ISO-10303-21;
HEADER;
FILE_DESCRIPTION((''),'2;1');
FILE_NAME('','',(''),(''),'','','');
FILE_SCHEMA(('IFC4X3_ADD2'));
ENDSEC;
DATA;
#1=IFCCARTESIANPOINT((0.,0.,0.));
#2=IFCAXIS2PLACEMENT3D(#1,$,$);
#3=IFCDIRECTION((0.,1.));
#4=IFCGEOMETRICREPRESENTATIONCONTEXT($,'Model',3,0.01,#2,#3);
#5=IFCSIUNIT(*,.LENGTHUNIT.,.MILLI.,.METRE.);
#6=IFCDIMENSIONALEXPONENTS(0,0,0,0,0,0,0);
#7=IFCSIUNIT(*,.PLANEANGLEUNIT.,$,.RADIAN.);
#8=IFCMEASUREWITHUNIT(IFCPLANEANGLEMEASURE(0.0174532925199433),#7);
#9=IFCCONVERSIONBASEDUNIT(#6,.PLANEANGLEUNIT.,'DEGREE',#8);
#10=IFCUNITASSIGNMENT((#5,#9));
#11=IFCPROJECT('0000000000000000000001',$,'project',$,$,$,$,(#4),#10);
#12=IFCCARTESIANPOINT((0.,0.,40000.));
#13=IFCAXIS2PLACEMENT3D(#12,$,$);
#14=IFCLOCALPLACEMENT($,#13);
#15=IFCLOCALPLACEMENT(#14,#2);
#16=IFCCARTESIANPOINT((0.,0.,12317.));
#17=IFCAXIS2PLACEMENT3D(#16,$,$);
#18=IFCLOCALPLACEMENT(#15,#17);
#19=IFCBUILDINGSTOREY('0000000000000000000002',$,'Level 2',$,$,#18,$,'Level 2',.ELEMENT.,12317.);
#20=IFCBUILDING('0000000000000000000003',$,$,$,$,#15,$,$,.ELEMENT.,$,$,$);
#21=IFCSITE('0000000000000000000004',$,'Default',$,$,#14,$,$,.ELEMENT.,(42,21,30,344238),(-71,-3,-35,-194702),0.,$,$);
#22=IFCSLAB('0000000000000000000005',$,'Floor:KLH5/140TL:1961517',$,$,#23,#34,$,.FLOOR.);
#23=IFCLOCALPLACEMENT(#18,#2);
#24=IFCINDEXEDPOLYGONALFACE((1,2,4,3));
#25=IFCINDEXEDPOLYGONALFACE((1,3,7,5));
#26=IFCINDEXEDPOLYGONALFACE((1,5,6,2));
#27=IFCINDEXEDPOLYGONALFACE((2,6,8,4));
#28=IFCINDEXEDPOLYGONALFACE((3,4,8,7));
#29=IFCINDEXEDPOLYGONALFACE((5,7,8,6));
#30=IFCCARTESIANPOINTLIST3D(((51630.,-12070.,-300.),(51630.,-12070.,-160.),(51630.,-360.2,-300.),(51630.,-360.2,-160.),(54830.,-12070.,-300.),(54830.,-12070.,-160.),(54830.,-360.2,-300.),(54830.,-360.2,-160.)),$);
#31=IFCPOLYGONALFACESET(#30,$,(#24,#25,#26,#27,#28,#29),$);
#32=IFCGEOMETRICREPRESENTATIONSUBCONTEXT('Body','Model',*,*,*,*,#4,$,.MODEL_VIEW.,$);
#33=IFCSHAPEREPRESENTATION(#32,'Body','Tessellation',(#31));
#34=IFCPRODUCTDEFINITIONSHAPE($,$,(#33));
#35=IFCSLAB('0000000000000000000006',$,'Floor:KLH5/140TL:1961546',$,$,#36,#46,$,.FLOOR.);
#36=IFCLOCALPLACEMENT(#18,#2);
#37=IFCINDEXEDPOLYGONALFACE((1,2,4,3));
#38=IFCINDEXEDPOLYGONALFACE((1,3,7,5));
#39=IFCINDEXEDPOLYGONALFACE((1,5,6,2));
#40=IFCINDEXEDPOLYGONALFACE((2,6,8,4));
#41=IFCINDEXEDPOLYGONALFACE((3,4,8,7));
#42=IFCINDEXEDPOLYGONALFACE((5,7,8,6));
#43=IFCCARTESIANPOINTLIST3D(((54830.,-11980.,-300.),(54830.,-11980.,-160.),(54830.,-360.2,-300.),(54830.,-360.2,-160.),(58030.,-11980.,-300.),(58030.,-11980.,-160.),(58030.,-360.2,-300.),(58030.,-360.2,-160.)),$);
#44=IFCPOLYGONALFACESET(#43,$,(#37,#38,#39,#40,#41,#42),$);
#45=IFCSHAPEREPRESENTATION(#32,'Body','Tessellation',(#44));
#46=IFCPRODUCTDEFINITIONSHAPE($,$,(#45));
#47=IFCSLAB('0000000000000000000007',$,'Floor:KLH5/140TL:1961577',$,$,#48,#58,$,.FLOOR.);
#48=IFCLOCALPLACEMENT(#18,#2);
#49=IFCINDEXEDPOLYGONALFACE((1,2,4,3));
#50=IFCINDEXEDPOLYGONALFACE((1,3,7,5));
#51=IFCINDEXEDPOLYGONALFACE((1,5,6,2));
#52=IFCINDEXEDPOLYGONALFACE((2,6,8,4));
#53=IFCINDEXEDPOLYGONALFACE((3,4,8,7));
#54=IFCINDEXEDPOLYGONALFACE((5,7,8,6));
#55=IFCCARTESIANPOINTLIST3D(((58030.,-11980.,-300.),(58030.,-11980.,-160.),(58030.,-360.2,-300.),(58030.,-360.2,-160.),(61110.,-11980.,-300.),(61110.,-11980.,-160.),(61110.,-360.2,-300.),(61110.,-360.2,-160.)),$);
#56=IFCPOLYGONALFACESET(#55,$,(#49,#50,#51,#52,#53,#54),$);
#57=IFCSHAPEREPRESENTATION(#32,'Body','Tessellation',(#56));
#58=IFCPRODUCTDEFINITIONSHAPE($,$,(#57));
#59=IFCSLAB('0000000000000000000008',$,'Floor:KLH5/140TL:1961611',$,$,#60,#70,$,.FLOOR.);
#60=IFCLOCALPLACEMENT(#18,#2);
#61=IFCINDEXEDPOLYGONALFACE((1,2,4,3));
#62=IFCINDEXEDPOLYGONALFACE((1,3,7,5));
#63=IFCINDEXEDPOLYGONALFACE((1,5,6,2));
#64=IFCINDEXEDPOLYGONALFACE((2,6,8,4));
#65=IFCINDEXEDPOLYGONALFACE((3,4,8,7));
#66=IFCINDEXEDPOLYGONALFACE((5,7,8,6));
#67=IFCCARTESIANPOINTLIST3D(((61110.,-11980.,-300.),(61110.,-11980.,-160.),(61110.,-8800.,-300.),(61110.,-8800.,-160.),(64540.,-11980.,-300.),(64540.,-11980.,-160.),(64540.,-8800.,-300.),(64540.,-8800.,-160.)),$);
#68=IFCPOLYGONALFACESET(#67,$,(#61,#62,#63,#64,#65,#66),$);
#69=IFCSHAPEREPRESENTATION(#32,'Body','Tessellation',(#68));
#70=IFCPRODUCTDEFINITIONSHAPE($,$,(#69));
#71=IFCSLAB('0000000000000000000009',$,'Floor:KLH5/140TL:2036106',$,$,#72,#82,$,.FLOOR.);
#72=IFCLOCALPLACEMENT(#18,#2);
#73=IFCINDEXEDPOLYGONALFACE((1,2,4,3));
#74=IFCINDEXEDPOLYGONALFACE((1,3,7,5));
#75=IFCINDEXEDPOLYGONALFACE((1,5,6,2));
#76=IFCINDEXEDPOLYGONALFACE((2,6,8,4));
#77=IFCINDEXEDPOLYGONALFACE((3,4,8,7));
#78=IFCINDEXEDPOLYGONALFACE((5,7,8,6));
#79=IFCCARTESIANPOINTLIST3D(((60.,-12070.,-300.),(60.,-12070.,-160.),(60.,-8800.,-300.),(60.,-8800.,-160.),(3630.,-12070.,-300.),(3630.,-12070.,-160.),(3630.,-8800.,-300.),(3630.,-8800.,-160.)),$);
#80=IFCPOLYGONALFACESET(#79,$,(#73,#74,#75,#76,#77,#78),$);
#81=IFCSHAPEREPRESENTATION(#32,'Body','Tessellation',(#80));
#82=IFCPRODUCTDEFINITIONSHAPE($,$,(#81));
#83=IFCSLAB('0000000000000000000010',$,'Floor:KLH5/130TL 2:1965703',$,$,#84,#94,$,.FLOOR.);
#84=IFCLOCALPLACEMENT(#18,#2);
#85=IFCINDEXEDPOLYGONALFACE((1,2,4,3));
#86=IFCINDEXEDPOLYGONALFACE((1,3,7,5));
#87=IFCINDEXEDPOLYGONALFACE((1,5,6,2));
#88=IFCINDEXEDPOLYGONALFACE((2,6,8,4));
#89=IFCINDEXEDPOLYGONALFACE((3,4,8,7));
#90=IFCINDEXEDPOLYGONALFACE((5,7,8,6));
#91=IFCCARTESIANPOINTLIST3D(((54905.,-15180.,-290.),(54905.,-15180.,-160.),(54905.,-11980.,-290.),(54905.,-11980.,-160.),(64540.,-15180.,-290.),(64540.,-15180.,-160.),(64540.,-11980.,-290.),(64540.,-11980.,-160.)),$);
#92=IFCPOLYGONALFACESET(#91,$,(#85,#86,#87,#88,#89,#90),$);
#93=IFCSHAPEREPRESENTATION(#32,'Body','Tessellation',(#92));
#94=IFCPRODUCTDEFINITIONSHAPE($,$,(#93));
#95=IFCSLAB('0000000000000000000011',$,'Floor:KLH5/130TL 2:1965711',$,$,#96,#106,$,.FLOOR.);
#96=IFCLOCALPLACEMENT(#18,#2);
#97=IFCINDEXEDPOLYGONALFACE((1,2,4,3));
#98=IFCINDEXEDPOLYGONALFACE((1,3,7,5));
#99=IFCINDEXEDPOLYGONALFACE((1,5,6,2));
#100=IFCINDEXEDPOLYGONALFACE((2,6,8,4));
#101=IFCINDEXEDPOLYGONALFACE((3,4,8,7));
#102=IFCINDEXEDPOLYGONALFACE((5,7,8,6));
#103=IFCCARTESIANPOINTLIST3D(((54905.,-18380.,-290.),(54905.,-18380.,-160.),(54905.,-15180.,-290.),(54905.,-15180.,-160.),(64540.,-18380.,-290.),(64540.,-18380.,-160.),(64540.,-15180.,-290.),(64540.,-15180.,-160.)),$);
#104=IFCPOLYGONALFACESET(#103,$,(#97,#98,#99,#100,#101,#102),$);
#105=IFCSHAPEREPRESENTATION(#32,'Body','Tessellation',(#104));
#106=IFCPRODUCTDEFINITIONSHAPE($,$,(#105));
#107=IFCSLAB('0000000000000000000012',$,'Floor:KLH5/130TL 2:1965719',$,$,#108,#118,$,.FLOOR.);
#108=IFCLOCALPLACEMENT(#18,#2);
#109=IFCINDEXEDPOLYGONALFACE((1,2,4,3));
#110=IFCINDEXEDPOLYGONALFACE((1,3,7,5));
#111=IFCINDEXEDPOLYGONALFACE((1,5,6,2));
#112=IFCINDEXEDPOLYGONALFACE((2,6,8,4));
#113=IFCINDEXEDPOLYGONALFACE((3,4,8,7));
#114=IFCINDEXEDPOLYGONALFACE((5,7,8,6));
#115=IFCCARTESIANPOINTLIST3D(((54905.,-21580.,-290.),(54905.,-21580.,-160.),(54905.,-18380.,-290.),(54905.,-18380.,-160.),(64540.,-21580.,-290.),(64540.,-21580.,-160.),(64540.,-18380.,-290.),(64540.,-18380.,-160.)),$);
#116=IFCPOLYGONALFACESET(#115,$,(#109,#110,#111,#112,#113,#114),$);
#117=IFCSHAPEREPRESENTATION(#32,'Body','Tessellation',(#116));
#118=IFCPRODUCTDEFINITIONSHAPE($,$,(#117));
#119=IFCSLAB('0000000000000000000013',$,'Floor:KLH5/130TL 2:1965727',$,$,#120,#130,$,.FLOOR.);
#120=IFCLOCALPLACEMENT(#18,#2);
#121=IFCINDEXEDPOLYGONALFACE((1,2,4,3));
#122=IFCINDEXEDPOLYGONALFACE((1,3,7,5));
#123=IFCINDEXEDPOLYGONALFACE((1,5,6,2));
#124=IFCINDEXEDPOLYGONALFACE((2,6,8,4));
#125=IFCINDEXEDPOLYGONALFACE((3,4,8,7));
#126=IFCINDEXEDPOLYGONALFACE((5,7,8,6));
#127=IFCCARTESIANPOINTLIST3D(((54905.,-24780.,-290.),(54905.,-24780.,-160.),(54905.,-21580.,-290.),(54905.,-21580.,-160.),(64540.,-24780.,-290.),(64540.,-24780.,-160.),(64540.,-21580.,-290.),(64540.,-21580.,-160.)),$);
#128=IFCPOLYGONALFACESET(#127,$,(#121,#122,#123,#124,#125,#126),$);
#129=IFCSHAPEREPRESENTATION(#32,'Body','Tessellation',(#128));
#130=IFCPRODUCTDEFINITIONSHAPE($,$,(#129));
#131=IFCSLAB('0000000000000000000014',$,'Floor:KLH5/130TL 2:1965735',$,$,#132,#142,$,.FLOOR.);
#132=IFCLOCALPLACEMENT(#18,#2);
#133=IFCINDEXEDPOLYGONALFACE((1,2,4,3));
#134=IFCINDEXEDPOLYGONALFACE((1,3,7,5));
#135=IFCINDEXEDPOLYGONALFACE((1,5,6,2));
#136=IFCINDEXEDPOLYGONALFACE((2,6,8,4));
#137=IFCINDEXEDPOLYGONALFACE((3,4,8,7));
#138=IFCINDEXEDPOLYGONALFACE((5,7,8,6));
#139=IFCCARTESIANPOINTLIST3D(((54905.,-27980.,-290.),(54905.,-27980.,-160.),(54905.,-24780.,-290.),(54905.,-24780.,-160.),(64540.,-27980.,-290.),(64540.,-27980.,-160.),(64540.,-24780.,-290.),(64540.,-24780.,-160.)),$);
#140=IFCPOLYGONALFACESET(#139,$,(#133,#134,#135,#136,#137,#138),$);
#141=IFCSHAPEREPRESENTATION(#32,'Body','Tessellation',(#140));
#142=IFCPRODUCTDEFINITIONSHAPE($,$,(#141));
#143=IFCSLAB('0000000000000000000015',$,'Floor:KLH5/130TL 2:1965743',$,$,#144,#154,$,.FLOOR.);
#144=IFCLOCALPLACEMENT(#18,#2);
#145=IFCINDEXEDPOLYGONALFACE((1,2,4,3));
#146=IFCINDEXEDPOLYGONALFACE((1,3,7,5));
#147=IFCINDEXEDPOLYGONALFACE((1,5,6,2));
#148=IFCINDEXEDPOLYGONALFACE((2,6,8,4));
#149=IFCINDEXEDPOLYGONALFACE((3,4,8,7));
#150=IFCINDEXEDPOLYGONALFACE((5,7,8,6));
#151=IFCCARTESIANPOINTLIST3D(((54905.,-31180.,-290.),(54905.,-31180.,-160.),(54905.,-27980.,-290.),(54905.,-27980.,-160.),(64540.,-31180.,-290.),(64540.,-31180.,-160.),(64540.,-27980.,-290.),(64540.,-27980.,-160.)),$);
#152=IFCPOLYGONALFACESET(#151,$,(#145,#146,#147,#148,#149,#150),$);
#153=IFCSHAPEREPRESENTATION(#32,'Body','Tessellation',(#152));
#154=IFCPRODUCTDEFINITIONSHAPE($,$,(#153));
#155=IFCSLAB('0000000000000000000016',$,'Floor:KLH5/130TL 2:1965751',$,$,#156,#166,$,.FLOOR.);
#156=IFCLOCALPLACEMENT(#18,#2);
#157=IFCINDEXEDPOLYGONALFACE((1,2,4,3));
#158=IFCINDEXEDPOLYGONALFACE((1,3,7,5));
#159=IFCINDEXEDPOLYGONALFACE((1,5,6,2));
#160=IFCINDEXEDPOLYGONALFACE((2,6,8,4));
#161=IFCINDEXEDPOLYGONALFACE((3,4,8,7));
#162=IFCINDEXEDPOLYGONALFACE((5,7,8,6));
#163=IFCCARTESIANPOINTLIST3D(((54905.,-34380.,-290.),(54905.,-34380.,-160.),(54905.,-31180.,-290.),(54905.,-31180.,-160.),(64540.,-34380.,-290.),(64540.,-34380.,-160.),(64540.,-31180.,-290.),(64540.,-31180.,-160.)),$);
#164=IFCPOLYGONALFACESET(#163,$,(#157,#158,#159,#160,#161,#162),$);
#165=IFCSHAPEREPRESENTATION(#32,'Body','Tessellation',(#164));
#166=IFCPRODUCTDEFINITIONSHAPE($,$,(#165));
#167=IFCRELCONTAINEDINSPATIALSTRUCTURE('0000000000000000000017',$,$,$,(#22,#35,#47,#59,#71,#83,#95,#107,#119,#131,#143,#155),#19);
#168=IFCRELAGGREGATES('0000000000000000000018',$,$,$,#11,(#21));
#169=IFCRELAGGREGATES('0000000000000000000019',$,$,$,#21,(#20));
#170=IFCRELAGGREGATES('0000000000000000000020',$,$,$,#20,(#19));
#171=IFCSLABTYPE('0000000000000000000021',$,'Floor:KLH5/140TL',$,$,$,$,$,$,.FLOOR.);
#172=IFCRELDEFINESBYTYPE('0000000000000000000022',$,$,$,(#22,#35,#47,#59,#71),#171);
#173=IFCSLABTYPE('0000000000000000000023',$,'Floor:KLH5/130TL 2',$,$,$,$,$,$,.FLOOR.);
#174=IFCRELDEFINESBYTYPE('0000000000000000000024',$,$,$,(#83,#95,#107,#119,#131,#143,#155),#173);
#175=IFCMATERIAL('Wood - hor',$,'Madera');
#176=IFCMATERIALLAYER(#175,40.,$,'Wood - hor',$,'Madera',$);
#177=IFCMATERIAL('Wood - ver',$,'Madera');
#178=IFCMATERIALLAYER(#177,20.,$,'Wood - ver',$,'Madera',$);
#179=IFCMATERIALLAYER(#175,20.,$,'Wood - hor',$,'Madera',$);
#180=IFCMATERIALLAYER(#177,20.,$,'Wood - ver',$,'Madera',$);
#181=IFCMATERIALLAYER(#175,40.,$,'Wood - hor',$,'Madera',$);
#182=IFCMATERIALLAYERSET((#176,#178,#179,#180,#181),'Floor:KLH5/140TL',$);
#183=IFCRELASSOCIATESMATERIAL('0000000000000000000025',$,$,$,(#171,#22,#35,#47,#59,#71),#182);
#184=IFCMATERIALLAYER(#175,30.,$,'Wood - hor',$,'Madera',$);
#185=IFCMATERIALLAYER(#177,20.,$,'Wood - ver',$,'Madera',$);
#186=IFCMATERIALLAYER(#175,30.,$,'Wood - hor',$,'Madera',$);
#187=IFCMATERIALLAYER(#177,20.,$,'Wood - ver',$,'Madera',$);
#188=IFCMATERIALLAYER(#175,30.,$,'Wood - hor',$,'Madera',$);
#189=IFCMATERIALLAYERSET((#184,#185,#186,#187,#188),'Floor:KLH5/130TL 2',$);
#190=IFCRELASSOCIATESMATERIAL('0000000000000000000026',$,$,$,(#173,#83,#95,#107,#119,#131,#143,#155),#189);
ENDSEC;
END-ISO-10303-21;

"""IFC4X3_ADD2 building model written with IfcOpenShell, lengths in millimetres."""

from ifc_helpers import new_model, entity, si_unit, converted_unit, direction, frame, frame_2d, origin, origin_2d_with_axis, place, context, subcontext, project, spatial, rectangle, extrude, material, layer, layer_set, layer_usage, type_object, element, save


model = new_model("IFC4X3_ADD2")

# Units and contexts
model_context = context("Model", 3, precision=0.01, world=origin(), true_north=direction((0.0, 1.0)))
body_context = subcontext(model_context, "Body", "Model", "MODEL_VIEW")
ifc_project = project(units=[si_unit("LENGTHUNIT", "METRE", prefix="MILLI"), converted_unit("PLANEANGLEUNIT", "DEGREE", entity("IfcPlaneAngleMeasure", 0.0174532925199433), si_unit("PLANEANGLEUNIT", "RADIAN"), dimensions=[0, 0, 0, 0, 0, 0, 0])], contexts=[model_context])

# Site, building, storey
site_placement = place(None, frame((0.0, 0.0, 40000.0)))
site = spatial("IfcSite", under=ifc_project, at=site_placement, Name="Default", CompositionType="ELEMENT", RefLatitude=(42, 21, 30, 344238), RefLongitude=(-71, -3, -35, -194702), RefElevation=0.0)
building_placement = place(site_placement, origin())
building = spatial("IfcBuilding", under=site, at=building_placement, CompositionType="ELEMENT")
storey_placement = place(building_placement, frame((0.0, 0.0, 12317.0)))
storey = spatial("IfcBuildingStorey", under=building, at=storey_placement, Name="Level 2", LongName="Level 2", CompositionType="ELEMENT", Elevation=12317.0)

# Slabs
ifc_material_1 = material(Name="Wood - hor", Category="Madera")
ifc_layer_1 = layer(ifc_material_1, 40.0, Name="Wood - hor", Category="Madera")
ifc_material_2 = material(Name="Wood - ver", Category="Madera")
ifc_layer_2 = layer(ifc_material_2, 20.0, Name="Wood - ver", Category="Madera")
ifc_layer_3 = layer(ifc_material_1, 20.0, Name="Wood - hor", Category="Madera")
ifc_layer_4 = layer(ifc_material_2, 20.0, Name="Wood - ver", Category="Madera")
ifc_layer_5 = layer(ifc_material_1, 40.0, Name="Wood - hor", Category="Madera")
ifc_layer_set_1 = layer_set([ifc_layer_1, ifc_layer_2, ifc_layer_3, ifc_layer_4, ifc_layer_5], Name="Floor:KLH5/140TL")
slab_type_1 = type_object("IfcSlabType", Name="Floor:KLH5/140TL", PredefinedType="FLOOR", material=ifc_layer_set_1)
ifc_layer_usage_1 = layer_usage(ifc_layer_set_1, "AXIS3", "POSITIVE", 0.0)
slab_1_placement = place(storey_placement, origin())
element("IfcSlab", 1, at=slab_1_placement, inside=storey, type_object=slab_type_1, material=ifc_layer_usage_1, Name="Floor:KLH5/140TL:1961517", PredefinedType="FLOOR", context=body_context, shape_type="SweptSolid", body=[
    extrude(rectangle(XDim=11709.8, YDim=3200.0, at=frame_2d((0.0, 0.0), x_axis=(1.0, 0.0))), frame((53230.0, -6215.1, -160.0), z_axis=(0.0, 0.0, -1.0), x_axis=(0.0, 1.0, 0.0)), (0.0, 0.0, 1.0), 140.0),
])
ifc_layer_usage_2 = layer_usage(ifc_layer_set_1, "AXIS3", "POSITIVE", 0.0)
slab_2_placement = place(storey_placement, origin())
element("IfcSlab", 2, at=slab_2_placement, inside=storey, type_object=slab_type_1, material=ifc_layer_usage_2, Name="Floor:KLH5/140TL:1961546", PredefinedType="FLOOR", context=body_context, shape_type="SweptSolid", body=[
    extrude(rectangle(XDim=11619.8, YDim=3200.0, at=origin_2d_with_axis()), frame((56430.0, -6170.1, -160.0), z_axis=(0.0, 0.0, -1.0), x_axis=(0.0, 1.0, 0.0)), (0.0, 0.0, 1.0), 140.0),
])
ifc_layer_usage_3 = layer_usage(ifc_layer_set_1, "AXIS3", "POSITIVE", 0.0)
slab_3_placement = place(storey_placement, origin())
element("IfcSlab", 3, at=slab_3_placement, inside=storey, type_object=slab_type_1, material=ifc_layer_usage_3, Name="Floor:KLH5/140TL:1961577", PredefinedType="FLOOR", context=body_context, shape_type="SweptSolid", body=[
    extrude(rectangle(XDim=11619.8, YDim=3080.0, at=origin_2d_with_axis()), frame((59570.0, -6170.1, -160.0), z_axis=(0.0, 0.0, -1.0), x_axis=(0.0, 1.0, 0.0)), (0.0, 0.0, 1.0), 140.0),
])
ifc_layer_usage_4 = layer_usage(ifc_layer_set_1, "AXIS3", "POSITIVE", 0.0)
slab_4_placement = place(storey_placement, origin())
element("IfcSlab", 4, at=slab_4_placement, inside=storey, type_object=slab_type_1, material=ifc_layer_usage_4, Name="Floor:KLH5/140TL:1961611", PredefinedType="FLOOR", context=body_context, shape_type="SweptSolid", body=[
    extrude(rectangle(XDim=3180.0, YDim=3430.0, at=frame_2d((0.0, 0.0), x_axis=(1.0, 0.0))), frame((62825.0, -10390.0, -160.0), z_axis=(0.0, 0.0, -1.0), x_axis=(0.0, 1.0, 0.0)), (0.0, 0.0, 1.0), 140.0),
])
ifc_layer_usage_5 = layer_usage(ifc_layer_set_1, "AXIS3", "POSITIVE", 0.0)
slab_5_placement = place(storey_placement, origin())
element("IfcSlab", 5, at=slab_5_placement, inside=storey, type_object=slab_type_1, material=ifc_layer_usage_5, Name="Floor:KLH5/140TL:2036106", PredefinedType="FLOOR", context=body_context, shape_type="SweptSolid", body=[
    extrude(rectangle(XDim=3270.0, YDim=3570.0, at=frame_2d((0.0, 0.0), x_axis=(1.0, 0.0))), frame((1845.0, -10435.0, -160.0), z_axis=(0.0, 0.0, -1.0), x_axis=(0.0, 1.0, 0.0)), (0.0, 0.0, 1.0), 140.0),
])
ifc_layer_6 = layer(ifc_material_1, 30.0, Name="Wood - hor", Category="Madera")
ifc_layer_7 = layer(ifc_material_2, 20.0, Name="Wood - ver", Category="Madera")
ifc_layer_8 = layer(ifc_material_1, 30.0, Name="Wood - hor", Category="Madera")
ifc_layer_9 = layer(ifc_material_2, 20.0, Name="Wood - ver", Category="Madera")
ifc_layer_10 = layer(ifc_material_1, 30.0, Name="Wood - hor", Category="Madera")
ifc_layer_set_2 = layer_set([ifc_layer_6, ifc_layer_7, ifc_layer_8, ifc_layer_9, ifc_layer_10], Name="Floor:KLH5/130TL 2")
ifc_layer_usage_6 = layer_usage(ifc_layer_set_2, "AXIS3", "POSITIVE", 0.0)
slab_type_2 = type_object("IfcSlabType", Name="Floor:KLH5/130TL 2", PredefinedType="FLOOR", material=ifc_layer_set_2)
slab_6_placement = place(storey_placement, origin())
element("IfcSlab", 6, at=slab_6_placement, inside=storey, type_object=slab_type_2, material=ifc_layer_usage_6, Name="Floor:KLH5/130TL 2:1965703", PredefinedType="FLOOR", context=body_context, shape_type="SweptSolid", body=[
    extrude(rectangle(XDim=3200.0, YDim=9635.0, at=origin_2d_with_axis()), frame((59722.5, -13580.0, -160.0), z_axis=(0.0, 0.0, -1.0), x_axis=(0.0, 1.0, 0.0)), (0.0, 0.0, 1.0), 130.0),
])
ifc_layer_usage_7 = layer_usage(ifc_layer_set_2, "AXIS3", "POSITIVE", 0.0)
slab_7_placement = place(storey_placement, origin())
element("IfcSlab", 7, at=slab_7_placement, inside=storey, type_object=slab_type_2, material=ifc_layer_usage_7, Name="Floor:KLH5/130TL 2:1965711", PredefinedType="FLOOR", context=body_context, shape_type="SweptSolid", body=[
    extrude(rectangle(XDim=3200.0, YDim=9635.0, at=frame_2d((0.0, 0.0), x_axis=(1.0, 0.0))), frame((59722.5, -16780.0, -160.0), z_axis=(0.0, 0.0, -1.0), x_axis=(0.0, 1.0, 0.0)), (0.0, 0.0, 1.0), 130.0),
])
ifc_layer_usage_8 = layer_usage(ifc_layer_set_2, "AXIS3", "POSITIVE", 0.0)
slab_8_placement = place(storey_placement, origin())
element("IfcSlab", 8, at=slab_8_placement, inside=storey, type_object=slab_type_2, material=ifc_layer_usage_8, Name="Floor:KLH5/130TL 2:1965719", PredefinedType="FLOOR", context=body_context, shape_type="SweptSolid", body=[
    extrude(rectangle(XDim=3200.0, YDim=9635.0, at=frame_2d((0.0, 0.0), x_axis=(1.0, 0.0))), frame((59722.5, -19980.0, -160.0), z_axis=(0.0, 0.0, -1.0), x_axis=(0.0, 1.0, 0.0)), (0.0, 0.0, 1.0), 130.0),
])
ifc_layer_usage_9 = layer_usage(ifc_layer_set_2, "AXIS3", "POSITIVE", 0.0)
slab_9_placement = place(storey_placement, origin())
element("IfcSlab", 9, at=slab_9_placement, inside=storey, type_object=slab_type_2, material=ifc_layer_usage_9, Name="Floor:KLH5/130TL 2:1965727", PredefinedType="FLOOR", context=body_context, shape_type="SweptSolid", body=[
    extrude(rectangle(XDim=3200.0, YDim=9635.0, at=origin_2d_with_axis()), frame((59722.5, -23180.0, -160.0), z_axis=(0.0, 0.0, -1.0), x_axis=(0.0, 1.0, 0.0)), (0.0, 0.0, 1.0), 130.0),
])
ifc_layer_usage_10 = layer_usage(ifc_layer_set_2, "AXIS3", "POSITIVE", 0.0)
slab_10_placement = place(storey_placement, origin())
element("IfcSlab", 10, at=slab_10_placement, inside=storey, type_object=slab_type_2, material=ifc_layer_usage_10, Name="Floor:KLH5/130TL 2:1965735", PredefinedType="FLOOR", context=body_context, shape_type="SweptSolid", body=[
    extrude(rectangle(XDim=3200.0, YDim=9635.0, at=origin_2d_with_axis()), frame((59722.5, -26380.0, -160.0), z_axis=(0.0, 0.0, -1.0), x_axis=(0.0, 1.0, 0.0)), (0.0, 0.0, 1.0), 130.0),
])
ifc_layer_usage_11 = layer_usage(ifc_layer_set_2, "AXIS3", "POSITIVE", 0.0)
slab_11_placement = place(storey_placement, origin())
element("IfcSlab", 11, at=slab_11_placement, inside=storey, type_object=slab_type_2, material=ifc_layer_usage_11, Name="Floor:KLH5/130TL 2:1965743", PredefinedType="FLOOR", context=body_context, shape_type="SweptSolid", body=[
    extrude(rectangle(XDim=3200.0, YDim=9635.0, at=frame_2d((0.0, 0.0), x_axis=(1.0, 0.0))), frame((59722.5, -29580.0, -160.0), z_axis=(0.0, 0.0, -1.0), x_axis=(0.0, 1.0, 0.0)), (0.0, 0.0, 1.0), 130.0),
])
ifc_layer_usage_12 = layer_usage(ifc_layer_set_2, "AXIS3", "POSITIVE", 0.0)
slab_12_placement = place(storey_placement, origin())
element("IfcSlab", 12, at=slab_12_placement, inside=storey, type_object=slab_type_2, material=ifc_layer_usage_12, Name="Floor:KLH5/130TL 2:1965751", PredefinedType="FLOOR", context=body_context, shape_type="SweptSolid", body=[
    extrude(rectangle(XDim=3200.0, YDim=9635.0, at=origin_2d_with_axis()), frame((59722.5, -32780.0, -160.0), z_axis=(0.0, 0.0, -1.0), x_axis=(0.0, 1.0, 0.0)), (0.0, 0.0, 1.0), 130.0),
])

save(model, "model.ifc")
